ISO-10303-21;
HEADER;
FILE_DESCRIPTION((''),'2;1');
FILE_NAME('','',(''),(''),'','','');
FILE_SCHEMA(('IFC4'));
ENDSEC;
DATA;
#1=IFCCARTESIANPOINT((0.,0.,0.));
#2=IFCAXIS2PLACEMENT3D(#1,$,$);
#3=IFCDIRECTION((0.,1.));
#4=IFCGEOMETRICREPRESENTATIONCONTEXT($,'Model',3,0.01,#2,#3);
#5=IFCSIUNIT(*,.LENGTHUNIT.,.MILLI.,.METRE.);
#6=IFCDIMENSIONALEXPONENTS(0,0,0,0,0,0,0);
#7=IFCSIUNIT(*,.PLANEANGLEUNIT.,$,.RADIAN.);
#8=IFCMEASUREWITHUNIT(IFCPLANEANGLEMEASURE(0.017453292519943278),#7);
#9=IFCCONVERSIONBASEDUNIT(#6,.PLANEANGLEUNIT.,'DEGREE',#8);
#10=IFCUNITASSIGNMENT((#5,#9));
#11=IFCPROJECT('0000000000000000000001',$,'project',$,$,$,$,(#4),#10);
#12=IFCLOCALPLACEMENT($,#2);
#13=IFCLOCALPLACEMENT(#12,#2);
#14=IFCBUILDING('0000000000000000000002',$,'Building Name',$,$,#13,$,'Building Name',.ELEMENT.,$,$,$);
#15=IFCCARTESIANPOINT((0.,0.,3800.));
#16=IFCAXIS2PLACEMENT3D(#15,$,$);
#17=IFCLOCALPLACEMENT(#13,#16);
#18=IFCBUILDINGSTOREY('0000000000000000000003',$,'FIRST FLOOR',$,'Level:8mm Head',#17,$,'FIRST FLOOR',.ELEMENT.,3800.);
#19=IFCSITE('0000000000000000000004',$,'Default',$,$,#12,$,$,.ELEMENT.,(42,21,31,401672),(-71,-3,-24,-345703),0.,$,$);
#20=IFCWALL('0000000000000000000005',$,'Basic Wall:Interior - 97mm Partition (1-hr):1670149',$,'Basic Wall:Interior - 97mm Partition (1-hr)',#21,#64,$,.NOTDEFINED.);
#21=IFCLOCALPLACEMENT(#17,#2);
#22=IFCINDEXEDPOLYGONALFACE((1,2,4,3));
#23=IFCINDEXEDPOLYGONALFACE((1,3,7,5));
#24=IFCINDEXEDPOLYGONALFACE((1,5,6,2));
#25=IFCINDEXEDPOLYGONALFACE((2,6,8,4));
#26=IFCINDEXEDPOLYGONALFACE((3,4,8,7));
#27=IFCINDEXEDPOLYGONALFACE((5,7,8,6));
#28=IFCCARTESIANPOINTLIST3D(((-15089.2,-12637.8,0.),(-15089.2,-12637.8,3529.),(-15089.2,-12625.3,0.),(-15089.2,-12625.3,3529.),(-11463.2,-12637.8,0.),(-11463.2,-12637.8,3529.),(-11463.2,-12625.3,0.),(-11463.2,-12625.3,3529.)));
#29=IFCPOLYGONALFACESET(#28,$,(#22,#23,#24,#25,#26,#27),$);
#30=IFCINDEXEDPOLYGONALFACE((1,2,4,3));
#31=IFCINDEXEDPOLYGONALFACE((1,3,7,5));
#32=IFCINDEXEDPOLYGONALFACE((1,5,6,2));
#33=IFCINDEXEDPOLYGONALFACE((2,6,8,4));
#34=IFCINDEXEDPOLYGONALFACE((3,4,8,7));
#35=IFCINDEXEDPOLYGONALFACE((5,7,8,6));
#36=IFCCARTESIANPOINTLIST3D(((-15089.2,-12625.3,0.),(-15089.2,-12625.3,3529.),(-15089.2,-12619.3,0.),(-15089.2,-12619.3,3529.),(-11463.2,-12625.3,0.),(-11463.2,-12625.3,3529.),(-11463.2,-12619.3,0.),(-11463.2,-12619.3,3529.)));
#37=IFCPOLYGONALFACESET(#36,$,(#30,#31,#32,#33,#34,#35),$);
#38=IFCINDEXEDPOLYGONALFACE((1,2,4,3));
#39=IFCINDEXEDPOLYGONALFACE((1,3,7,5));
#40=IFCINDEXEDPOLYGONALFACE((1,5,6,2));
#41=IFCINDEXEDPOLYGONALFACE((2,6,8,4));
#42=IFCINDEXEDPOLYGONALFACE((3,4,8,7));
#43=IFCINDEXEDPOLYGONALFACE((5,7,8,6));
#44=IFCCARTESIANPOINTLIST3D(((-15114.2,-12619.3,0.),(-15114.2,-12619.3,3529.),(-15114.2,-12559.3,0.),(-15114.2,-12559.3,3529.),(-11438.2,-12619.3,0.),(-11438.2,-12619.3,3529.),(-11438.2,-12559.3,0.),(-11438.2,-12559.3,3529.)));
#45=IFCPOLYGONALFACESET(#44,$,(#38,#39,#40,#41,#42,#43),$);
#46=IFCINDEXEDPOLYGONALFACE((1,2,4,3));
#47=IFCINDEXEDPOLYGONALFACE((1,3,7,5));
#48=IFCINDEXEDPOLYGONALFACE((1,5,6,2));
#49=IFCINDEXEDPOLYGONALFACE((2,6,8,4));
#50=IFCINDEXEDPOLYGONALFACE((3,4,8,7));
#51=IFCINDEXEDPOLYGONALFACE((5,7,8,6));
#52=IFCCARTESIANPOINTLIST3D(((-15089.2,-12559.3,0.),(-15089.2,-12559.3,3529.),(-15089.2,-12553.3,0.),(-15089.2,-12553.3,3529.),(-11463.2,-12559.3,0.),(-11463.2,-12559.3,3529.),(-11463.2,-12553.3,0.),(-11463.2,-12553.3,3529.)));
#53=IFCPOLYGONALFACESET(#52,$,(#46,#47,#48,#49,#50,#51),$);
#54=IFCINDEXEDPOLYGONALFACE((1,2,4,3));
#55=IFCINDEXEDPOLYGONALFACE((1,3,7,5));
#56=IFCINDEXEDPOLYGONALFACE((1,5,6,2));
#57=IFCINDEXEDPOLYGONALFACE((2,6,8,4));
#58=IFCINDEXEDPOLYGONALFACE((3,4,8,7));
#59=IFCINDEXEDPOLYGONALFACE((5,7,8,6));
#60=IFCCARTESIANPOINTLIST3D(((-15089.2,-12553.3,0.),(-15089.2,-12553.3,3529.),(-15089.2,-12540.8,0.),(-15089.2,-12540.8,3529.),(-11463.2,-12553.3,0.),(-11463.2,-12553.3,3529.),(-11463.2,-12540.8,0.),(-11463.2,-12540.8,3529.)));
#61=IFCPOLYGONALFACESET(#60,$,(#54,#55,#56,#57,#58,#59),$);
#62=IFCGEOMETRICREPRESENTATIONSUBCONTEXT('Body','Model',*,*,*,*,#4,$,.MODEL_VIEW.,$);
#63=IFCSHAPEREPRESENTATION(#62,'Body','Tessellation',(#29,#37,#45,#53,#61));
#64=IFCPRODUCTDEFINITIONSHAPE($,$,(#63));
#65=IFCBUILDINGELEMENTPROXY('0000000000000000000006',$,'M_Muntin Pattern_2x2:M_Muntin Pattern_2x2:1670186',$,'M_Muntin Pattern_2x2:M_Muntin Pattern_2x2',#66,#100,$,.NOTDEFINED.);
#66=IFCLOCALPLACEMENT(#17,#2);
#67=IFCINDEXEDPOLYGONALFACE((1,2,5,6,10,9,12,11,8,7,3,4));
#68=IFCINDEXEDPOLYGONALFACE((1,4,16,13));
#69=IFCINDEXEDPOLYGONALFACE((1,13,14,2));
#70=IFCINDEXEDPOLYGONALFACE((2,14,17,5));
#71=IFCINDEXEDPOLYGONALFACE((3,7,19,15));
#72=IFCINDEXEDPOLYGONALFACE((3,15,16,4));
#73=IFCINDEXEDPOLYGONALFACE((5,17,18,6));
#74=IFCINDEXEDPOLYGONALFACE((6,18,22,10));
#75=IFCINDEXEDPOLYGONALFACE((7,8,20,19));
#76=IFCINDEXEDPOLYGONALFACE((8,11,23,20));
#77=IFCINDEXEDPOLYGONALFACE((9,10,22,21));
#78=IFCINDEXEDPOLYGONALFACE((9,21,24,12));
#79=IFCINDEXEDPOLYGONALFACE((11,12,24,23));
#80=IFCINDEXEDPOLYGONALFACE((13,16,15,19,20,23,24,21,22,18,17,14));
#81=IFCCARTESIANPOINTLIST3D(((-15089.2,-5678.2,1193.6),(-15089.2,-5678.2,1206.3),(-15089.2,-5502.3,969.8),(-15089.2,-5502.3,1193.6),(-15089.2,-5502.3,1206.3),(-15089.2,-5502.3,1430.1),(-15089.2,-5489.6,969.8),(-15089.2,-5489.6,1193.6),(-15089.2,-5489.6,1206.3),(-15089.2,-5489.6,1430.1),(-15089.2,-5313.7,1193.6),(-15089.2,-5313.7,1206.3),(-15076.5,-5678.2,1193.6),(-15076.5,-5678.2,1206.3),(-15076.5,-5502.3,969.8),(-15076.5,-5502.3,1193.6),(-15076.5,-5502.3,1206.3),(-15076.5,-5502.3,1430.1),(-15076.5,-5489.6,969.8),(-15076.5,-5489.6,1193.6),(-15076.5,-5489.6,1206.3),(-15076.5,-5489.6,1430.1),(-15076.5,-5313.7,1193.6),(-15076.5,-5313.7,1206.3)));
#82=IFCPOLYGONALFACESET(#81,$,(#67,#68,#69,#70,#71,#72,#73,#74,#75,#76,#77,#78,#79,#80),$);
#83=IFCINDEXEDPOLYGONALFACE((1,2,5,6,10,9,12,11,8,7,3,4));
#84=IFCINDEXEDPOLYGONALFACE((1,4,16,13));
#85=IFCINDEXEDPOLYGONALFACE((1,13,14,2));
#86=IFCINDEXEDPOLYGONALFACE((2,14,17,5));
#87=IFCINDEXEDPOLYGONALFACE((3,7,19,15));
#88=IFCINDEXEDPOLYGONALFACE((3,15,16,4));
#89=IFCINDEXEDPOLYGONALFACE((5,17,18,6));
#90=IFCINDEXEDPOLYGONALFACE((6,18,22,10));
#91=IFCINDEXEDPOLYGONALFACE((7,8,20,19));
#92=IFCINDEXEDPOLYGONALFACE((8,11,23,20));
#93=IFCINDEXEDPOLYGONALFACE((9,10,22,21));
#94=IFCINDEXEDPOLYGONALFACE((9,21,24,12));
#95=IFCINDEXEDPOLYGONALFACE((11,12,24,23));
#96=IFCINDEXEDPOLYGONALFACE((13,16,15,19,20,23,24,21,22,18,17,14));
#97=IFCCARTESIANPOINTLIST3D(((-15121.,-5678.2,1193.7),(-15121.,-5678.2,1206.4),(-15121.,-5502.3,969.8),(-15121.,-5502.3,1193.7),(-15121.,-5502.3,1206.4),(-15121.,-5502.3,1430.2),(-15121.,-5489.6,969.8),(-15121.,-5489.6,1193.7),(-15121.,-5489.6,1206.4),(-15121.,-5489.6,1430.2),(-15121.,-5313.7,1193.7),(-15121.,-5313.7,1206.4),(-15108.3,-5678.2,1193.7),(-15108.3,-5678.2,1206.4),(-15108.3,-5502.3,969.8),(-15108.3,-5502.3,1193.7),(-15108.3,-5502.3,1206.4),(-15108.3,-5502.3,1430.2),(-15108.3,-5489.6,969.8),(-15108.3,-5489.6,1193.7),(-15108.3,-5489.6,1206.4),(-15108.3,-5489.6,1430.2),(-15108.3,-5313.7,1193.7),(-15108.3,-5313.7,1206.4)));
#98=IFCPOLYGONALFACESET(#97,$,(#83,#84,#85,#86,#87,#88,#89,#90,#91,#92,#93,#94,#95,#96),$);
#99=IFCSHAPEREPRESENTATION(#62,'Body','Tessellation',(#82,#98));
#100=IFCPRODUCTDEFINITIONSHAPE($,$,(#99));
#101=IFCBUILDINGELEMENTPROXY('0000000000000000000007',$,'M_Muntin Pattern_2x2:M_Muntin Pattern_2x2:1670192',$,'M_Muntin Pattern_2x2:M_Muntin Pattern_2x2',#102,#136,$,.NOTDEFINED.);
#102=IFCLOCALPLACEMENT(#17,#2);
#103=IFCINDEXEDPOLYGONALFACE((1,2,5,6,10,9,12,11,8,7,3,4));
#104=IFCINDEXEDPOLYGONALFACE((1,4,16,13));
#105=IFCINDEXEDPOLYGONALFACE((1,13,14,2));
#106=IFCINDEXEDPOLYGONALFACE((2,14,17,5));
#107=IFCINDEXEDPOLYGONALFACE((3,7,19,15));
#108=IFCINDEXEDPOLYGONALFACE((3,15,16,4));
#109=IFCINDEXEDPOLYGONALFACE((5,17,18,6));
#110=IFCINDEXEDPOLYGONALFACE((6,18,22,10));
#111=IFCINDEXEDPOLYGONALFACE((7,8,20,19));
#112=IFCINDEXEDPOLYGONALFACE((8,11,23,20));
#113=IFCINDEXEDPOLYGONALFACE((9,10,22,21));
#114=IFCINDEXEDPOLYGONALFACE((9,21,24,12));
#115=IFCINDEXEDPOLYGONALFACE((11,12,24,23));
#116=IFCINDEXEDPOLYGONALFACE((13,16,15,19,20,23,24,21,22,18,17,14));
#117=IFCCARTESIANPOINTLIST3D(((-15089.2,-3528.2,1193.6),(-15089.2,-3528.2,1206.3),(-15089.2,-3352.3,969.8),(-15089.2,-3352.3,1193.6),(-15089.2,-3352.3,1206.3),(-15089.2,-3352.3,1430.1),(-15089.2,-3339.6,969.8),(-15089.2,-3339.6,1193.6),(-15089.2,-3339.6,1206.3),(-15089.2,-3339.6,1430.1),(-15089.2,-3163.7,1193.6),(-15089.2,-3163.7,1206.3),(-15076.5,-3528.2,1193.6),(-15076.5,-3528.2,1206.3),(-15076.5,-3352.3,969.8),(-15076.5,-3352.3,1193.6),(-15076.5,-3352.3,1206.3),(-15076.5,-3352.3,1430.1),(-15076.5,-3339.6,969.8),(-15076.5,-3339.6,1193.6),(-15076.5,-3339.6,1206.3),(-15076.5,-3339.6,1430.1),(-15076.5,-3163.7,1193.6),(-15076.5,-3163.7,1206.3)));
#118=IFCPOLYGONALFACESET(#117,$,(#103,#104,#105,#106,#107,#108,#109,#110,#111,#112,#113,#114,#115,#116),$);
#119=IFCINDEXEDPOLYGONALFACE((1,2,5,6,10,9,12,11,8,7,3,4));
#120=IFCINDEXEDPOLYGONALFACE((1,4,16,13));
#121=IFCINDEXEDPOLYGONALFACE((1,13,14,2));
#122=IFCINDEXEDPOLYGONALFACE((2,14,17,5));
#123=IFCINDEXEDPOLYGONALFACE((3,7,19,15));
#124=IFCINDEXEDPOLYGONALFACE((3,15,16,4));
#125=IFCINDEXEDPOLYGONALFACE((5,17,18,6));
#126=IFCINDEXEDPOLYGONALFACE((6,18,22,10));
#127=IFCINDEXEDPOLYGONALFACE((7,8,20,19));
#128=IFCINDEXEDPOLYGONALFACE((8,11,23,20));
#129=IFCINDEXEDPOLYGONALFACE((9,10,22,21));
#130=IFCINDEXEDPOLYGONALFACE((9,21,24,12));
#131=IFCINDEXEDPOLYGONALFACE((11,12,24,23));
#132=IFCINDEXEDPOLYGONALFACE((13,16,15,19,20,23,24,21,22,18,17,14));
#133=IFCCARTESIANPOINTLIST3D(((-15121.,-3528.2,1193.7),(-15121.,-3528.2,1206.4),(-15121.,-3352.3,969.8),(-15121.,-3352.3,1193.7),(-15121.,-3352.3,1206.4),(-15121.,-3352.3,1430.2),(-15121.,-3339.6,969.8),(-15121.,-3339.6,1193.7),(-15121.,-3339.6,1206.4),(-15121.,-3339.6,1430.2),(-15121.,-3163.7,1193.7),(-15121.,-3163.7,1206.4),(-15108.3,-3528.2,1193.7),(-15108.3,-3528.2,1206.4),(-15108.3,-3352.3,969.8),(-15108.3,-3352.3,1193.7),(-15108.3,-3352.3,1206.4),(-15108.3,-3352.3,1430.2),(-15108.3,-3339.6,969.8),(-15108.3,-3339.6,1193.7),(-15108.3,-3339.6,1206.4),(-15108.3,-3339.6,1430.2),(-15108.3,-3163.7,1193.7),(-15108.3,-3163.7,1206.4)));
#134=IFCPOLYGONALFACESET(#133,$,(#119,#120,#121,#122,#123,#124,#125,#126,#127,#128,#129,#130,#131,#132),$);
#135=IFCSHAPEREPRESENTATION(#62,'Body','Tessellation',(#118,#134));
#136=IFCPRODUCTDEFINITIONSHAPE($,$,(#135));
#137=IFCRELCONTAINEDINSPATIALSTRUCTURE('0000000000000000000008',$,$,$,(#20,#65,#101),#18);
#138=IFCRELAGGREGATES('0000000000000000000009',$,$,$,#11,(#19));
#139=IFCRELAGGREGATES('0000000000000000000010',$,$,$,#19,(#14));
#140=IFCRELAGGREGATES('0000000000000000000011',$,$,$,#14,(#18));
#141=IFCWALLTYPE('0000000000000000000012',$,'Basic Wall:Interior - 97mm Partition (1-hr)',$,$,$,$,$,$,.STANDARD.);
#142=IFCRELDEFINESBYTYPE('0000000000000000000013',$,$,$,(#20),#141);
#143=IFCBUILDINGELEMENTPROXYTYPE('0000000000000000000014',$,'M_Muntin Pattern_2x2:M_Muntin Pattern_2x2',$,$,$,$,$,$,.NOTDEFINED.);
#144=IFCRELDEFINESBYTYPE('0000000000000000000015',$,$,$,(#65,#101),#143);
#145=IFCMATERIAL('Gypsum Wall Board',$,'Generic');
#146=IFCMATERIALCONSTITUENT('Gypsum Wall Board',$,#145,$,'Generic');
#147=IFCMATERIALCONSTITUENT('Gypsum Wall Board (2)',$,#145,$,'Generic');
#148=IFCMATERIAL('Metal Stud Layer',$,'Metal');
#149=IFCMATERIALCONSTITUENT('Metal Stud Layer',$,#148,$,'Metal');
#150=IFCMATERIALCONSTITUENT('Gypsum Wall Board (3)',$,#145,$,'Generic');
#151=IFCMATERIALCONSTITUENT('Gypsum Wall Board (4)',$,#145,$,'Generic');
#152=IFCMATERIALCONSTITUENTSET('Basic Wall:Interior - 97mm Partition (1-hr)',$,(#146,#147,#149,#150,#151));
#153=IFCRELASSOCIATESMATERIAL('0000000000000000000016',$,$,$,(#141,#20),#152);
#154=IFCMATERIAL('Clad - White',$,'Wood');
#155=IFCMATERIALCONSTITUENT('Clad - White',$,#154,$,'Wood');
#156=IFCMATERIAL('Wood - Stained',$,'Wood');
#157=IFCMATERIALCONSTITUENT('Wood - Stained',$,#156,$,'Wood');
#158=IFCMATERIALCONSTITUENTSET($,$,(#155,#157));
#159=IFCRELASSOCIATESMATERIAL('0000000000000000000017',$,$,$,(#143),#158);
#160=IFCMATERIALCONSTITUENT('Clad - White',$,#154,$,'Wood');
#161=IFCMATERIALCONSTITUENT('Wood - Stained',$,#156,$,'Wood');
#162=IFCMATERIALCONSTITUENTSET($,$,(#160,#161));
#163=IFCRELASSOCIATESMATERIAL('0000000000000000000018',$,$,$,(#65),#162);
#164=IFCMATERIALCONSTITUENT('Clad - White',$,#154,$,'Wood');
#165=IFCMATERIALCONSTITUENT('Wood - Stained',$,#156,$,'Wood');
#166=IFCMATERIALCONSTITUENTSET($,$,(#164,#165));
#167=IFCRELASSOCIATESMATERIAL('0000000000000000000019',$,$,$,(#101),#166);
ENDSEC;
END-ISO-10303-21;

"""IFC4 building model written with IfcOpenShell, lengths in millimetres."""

from ifc_helpers import new_model, entity, si_unit, converted_unit, direction, frame, origin, place, context, subcontext, project, spatial, indexed_curve, outline, extrude, source, transform, mapped, material, constituent, constituent_set, type_object, type_shapes, element, save


model = new_model("IFC4")

# Units and contexts
model_context = context("Model", 3, precision=0.01, world=origin(), true_north=direction((0.0, 1.0)))
body_context = subcontext(model_context, "Body", "Model", "MODEL_VIEW")
ifc_project = project(units=[si_unit("LENGTHUNIT", "METRE", prefix="MILLI"), converted_unit("PLANEANGLEUNIT", "DEGREE", entity("IfcPlaneAngleMeasure", 0.017453292519943278), si_unit("PLANEANGLEUNIT", "RADIAN"), dimensions=[0, 0, 0, 0, 0, 0, 0])], contexts=[model_context])

# Site, building, storey
site_placement = place(None, origin())
site = spatial("IfcSite", under=ifc_project, at=site_placement, Name="Default", CompositionType="ELEMENT", RefLatitude=(42, 21, 31, 401672), RefLongitude=(-71, -3, -24, -345703), RefElevation=0.0)
building_placement = place(site_placement, origin())
building = spatial("IfcBuilding", under=site, at=building_placement, Name="Building Name", LongName="Building Name", CompositionType="ELEMENT")
storey_placement = place(building_placement, frame((0.0, 0.0, 3800.0)))
storey = spatial("IfcBuildingStorey", under=building, at=storey_placement, Name="FIRST FLOOR", ObjectType="Level:8mm Head", LongName="FIRST FLOOR", CompositionType="ELEMENT", Elevation=3800.0)

# Shared definitions
ifc_material_1 = material(Name="Wood - Stained", Category="Wood")

# Wall
ifc_material_2 = material(Name="Gypsum Wall Board", Category="Generic")
ifc_constituent_1 = constituent(ifc_material_2, Name="Gypsum Wall Board", Category="Generic")
ifc_constituent_2 = constituent(ifc_material_2, Name="Gypsum Wall Board (2)", Category="Generic")
ifc_material_3 = material(Name="Metal Stud Layer", Category="Metal")
ifc_constituent_3 = constituent(ifc_material_3, Name="Metal Stud Layer", Category="Metal")
ifc_constituent_4 = constituent(ifc_material_2, Name="Gypsum Wall Board (3)", Category="Generic")
ifc_constituent_5 = constituent(ifc_material_2, Name="Gypsum Wall Board (4)", Category="Generic")
ifc_constituent_set_1 = constituent_set(constituents=[ifc_constituent_1, ifc_constituent_2, ifc_constituent_3, ifc_constituent_4, ifc_constituent_5], Name="Basic Wall:Interior - 97mm Partition (1-hr)")
wall_type_1 = type_object("IfcWallType", Name="Basic Wall:Interior - 97mm Partition (1-hr)", PredefinedType="STANDARD", material=ifc_constituent_set_1)
wall_1_placement = place(storey_placement, frame((-15089.2, -12589.3, 0.0)))
element("IfcWall", 1, at=wall_1_placement, inside=storey, type_object=wall_type_1, material=ifc_constituent_set_1, Name="Basic Wall:Interior - 97mm Partition (1-hr):1670149", ObjectType="Basic Wall:Interior - 97mm Partition (1-hr)", PredefinedType="NOTDEFINED", context=body_context, shape_type="SweptSolid", body=[
    extrude(outline(indexed_curve([(-6.3, -1813.0), (6.2, -1813.0), (6.3, 1813.0), (-6.2, 1813.0), (-6.3, -1813.0)], self_intersect=False)), frame((1813.0, -42.2, 0.0), z_axis=(0.0, 0.0, 1.0), x_axis=(0.0, 1.0, 0.0)), (0.0, 0.0, 1.0), 3529.0),
    extrude(outline(indexed_curve([(-1813.0, -3.0), (1813.0, -3.0), (1813.0, 3.0), (-1813.0, 3.0), (-1813.0, -3.0)], self_intersect=False)), frame((1813.0, -33.0, 0.0)), (0.0, 0.0, 1.0), 3529.0),
    extrude(outline(indexed_curve([(-1838.0, -30.0), (1838.0, -30.0), (1838.0, 30.0), (-1838.0, 30.0), (-1838.0, -30.0)], self_intersect=False)), frame((1813.0, 0.0, 0.0)), (0.0, 0.0, 1.0), 3529.0),
    extrude(outline(indexed_curve([(-1813.0, -3.0), (1813.0, -3.0), (1813.0, 3.0), (-1813.0, 3.0), (-1813.0, -3.0)], self_intersect=False)), frame((1813.0, 33.0, 0.0)), (0.0, 0.0, 1.0), 3529.0),
    extrude(outline(indexed_curve([(-6.3, -1813.0), (6.2, -1813.0), (6.3, 1813.0), (-6.2, 1813.0), (-6.3, -1813.0)], self_intersect=False)), frame((1813.0, 42.2, 0.0), z_axis=(0.0, 0.0, 1.0), x_axis=(0.0, -1.0, 0.0)), (0.0, 0.0, 1.0), 3529.0),
])

# Building element proxies
ifc_material_4 = material(Name="Clad - White", Category="Wood")
ifc_constituent_6 = constituent(ifc_material_4, Name="Clad - White", Category="Wood")
ifc_constituent_7 = constituent(ifc_material_1, Name="Wood - Stained", Category="Wood")
ifc_constituent_set_2 = constituent_set(constituents=[ifc_constituent_6, ifc_constituent_7])
ifc_constituent_8 = constituent(ifc_material_4, Name="Clad - White", Category="Wood")
ifc_constituent_9 = constituent(ifc_material_1, Name="Wood - Stained", Category="Wood")
ifc_constituent_set_3 = constituent_set(constituents=[ifc_constituent_8, ifc_constituent_9])
building_element_proxy_type_1 = type_object("IfcBuildingElementProxyType", Name="M_Muntin Pattern_2x2:M_Muntin Pattern_2x2", PredefinedType="NOTDEFINED", material=ifc_constituent_set_3)
shared_shape_1 = source(origin(), body_context, "Body", "SweptSolid", [
    extrude(outline(indexed_curve([(6.4, -6.4), (230.1, -6.4), (230.1, 6.3), (6.4, 6.3), (6.4, 182.3), (-6.3, 182.3), (-6.3, 6.3), (-230.2, 6.3), (-230.2, -6.4), (-6.3, -6.4), (-6.3, -182.3), (6.4, -182.3), (6.4, -6.4)], self_intersect=False)), frame((0.0, 9.5, 230.1), z_axis=(0.0, 1.0, 0.0), x_axis=(0.0, 0.0, 1.0)), (0.0, 0.0, 1.0), 12.7),
    extrude(outline(indexed_curve([(6.4, -6.4), (230.2, -6.4), (230.2, 6.3), (6.4, 6.3), (6.4, 182.3), (-6.3, 182.3), (-6.3, 6.3), (-230.2, 6.3), (-230.2, -6.4), (-6.3, -6.4), (-6.3, -182.3), (6.4, -182.3), (6.4, -6.4)], self_intersect=False)), frame((0.0, -22.2, 230.2), z_axis=(0.0, 1.0, 0.0), x_axis=(0.0, 0.0, 1.0)), (0.0, 0.0, 1.0), 12.7),
])
type_shapes(building_element_proxy_type_1, [shared_shape_1])
proxy_1_placement = place(storey_placement, frame((-15098.7, -5495.9, 969.8), z_axis=(0.0, 0.0, 1.0), x_axis=(0.0, -1.0, 0.0)))
element("IfcBuildingElementProxy", 2, at=proxy_1_placement, inside=storey, type_object=building_element_proxy_type_1, material=ifc_constituent_set_2, Name="M_Muntin Pattern_2x2:M_Muntin Pattern_2x2:1670186", ObjectType="M_Muntin Pattern_2x2:M_Muntin Pattern_2x2", PredefinedType="NOTDEFINED", context=body_context, shape_type="MappedRepresentation", body=[
    mapped(shared_shape_1, transform((0.0, 0.0, 0.0), scale=1.0)),
])
ifc_constituent_10 = constituent(ifc_material_4, Name="Clad - White", Category="Wood")
ifc_constituent_11 = constituent(ifc_material_1, Name="Wood - Stained", Category="Wood")
ifc_constituent_set_4 = constituent_set(constituents=[ifc_constituent_10, ifc_constituent_11])
proxy_2_placement = place(storey_placement, frame((-15098.7, -3345.9, 969.8), z_axis=(0.0, 0.0, 1.0), x_axis=(0.0, -1.0, 0.0)))
element("IfcBuildingElementProxy", 3, at=proxy_2_placement, inside=storey, type_object=building_element_proxy_type_1, material=ifc_constituent_set_4, Name="M_Muntin Pattern_2x2:M_Muntin Pattern_2x2:1670192", ObjectType="M_Muntin Pattern_2x2:M_Muntin Pattern_2x2", PredefinedType="NOTDEFINED", context=body_context, shape_type="MappedRepresentation", body=[
    mapped(shared_shape_1, transform((0.0, 0.0, 0.0), scale=1.0)),
])

save(model, "model.ifc")
